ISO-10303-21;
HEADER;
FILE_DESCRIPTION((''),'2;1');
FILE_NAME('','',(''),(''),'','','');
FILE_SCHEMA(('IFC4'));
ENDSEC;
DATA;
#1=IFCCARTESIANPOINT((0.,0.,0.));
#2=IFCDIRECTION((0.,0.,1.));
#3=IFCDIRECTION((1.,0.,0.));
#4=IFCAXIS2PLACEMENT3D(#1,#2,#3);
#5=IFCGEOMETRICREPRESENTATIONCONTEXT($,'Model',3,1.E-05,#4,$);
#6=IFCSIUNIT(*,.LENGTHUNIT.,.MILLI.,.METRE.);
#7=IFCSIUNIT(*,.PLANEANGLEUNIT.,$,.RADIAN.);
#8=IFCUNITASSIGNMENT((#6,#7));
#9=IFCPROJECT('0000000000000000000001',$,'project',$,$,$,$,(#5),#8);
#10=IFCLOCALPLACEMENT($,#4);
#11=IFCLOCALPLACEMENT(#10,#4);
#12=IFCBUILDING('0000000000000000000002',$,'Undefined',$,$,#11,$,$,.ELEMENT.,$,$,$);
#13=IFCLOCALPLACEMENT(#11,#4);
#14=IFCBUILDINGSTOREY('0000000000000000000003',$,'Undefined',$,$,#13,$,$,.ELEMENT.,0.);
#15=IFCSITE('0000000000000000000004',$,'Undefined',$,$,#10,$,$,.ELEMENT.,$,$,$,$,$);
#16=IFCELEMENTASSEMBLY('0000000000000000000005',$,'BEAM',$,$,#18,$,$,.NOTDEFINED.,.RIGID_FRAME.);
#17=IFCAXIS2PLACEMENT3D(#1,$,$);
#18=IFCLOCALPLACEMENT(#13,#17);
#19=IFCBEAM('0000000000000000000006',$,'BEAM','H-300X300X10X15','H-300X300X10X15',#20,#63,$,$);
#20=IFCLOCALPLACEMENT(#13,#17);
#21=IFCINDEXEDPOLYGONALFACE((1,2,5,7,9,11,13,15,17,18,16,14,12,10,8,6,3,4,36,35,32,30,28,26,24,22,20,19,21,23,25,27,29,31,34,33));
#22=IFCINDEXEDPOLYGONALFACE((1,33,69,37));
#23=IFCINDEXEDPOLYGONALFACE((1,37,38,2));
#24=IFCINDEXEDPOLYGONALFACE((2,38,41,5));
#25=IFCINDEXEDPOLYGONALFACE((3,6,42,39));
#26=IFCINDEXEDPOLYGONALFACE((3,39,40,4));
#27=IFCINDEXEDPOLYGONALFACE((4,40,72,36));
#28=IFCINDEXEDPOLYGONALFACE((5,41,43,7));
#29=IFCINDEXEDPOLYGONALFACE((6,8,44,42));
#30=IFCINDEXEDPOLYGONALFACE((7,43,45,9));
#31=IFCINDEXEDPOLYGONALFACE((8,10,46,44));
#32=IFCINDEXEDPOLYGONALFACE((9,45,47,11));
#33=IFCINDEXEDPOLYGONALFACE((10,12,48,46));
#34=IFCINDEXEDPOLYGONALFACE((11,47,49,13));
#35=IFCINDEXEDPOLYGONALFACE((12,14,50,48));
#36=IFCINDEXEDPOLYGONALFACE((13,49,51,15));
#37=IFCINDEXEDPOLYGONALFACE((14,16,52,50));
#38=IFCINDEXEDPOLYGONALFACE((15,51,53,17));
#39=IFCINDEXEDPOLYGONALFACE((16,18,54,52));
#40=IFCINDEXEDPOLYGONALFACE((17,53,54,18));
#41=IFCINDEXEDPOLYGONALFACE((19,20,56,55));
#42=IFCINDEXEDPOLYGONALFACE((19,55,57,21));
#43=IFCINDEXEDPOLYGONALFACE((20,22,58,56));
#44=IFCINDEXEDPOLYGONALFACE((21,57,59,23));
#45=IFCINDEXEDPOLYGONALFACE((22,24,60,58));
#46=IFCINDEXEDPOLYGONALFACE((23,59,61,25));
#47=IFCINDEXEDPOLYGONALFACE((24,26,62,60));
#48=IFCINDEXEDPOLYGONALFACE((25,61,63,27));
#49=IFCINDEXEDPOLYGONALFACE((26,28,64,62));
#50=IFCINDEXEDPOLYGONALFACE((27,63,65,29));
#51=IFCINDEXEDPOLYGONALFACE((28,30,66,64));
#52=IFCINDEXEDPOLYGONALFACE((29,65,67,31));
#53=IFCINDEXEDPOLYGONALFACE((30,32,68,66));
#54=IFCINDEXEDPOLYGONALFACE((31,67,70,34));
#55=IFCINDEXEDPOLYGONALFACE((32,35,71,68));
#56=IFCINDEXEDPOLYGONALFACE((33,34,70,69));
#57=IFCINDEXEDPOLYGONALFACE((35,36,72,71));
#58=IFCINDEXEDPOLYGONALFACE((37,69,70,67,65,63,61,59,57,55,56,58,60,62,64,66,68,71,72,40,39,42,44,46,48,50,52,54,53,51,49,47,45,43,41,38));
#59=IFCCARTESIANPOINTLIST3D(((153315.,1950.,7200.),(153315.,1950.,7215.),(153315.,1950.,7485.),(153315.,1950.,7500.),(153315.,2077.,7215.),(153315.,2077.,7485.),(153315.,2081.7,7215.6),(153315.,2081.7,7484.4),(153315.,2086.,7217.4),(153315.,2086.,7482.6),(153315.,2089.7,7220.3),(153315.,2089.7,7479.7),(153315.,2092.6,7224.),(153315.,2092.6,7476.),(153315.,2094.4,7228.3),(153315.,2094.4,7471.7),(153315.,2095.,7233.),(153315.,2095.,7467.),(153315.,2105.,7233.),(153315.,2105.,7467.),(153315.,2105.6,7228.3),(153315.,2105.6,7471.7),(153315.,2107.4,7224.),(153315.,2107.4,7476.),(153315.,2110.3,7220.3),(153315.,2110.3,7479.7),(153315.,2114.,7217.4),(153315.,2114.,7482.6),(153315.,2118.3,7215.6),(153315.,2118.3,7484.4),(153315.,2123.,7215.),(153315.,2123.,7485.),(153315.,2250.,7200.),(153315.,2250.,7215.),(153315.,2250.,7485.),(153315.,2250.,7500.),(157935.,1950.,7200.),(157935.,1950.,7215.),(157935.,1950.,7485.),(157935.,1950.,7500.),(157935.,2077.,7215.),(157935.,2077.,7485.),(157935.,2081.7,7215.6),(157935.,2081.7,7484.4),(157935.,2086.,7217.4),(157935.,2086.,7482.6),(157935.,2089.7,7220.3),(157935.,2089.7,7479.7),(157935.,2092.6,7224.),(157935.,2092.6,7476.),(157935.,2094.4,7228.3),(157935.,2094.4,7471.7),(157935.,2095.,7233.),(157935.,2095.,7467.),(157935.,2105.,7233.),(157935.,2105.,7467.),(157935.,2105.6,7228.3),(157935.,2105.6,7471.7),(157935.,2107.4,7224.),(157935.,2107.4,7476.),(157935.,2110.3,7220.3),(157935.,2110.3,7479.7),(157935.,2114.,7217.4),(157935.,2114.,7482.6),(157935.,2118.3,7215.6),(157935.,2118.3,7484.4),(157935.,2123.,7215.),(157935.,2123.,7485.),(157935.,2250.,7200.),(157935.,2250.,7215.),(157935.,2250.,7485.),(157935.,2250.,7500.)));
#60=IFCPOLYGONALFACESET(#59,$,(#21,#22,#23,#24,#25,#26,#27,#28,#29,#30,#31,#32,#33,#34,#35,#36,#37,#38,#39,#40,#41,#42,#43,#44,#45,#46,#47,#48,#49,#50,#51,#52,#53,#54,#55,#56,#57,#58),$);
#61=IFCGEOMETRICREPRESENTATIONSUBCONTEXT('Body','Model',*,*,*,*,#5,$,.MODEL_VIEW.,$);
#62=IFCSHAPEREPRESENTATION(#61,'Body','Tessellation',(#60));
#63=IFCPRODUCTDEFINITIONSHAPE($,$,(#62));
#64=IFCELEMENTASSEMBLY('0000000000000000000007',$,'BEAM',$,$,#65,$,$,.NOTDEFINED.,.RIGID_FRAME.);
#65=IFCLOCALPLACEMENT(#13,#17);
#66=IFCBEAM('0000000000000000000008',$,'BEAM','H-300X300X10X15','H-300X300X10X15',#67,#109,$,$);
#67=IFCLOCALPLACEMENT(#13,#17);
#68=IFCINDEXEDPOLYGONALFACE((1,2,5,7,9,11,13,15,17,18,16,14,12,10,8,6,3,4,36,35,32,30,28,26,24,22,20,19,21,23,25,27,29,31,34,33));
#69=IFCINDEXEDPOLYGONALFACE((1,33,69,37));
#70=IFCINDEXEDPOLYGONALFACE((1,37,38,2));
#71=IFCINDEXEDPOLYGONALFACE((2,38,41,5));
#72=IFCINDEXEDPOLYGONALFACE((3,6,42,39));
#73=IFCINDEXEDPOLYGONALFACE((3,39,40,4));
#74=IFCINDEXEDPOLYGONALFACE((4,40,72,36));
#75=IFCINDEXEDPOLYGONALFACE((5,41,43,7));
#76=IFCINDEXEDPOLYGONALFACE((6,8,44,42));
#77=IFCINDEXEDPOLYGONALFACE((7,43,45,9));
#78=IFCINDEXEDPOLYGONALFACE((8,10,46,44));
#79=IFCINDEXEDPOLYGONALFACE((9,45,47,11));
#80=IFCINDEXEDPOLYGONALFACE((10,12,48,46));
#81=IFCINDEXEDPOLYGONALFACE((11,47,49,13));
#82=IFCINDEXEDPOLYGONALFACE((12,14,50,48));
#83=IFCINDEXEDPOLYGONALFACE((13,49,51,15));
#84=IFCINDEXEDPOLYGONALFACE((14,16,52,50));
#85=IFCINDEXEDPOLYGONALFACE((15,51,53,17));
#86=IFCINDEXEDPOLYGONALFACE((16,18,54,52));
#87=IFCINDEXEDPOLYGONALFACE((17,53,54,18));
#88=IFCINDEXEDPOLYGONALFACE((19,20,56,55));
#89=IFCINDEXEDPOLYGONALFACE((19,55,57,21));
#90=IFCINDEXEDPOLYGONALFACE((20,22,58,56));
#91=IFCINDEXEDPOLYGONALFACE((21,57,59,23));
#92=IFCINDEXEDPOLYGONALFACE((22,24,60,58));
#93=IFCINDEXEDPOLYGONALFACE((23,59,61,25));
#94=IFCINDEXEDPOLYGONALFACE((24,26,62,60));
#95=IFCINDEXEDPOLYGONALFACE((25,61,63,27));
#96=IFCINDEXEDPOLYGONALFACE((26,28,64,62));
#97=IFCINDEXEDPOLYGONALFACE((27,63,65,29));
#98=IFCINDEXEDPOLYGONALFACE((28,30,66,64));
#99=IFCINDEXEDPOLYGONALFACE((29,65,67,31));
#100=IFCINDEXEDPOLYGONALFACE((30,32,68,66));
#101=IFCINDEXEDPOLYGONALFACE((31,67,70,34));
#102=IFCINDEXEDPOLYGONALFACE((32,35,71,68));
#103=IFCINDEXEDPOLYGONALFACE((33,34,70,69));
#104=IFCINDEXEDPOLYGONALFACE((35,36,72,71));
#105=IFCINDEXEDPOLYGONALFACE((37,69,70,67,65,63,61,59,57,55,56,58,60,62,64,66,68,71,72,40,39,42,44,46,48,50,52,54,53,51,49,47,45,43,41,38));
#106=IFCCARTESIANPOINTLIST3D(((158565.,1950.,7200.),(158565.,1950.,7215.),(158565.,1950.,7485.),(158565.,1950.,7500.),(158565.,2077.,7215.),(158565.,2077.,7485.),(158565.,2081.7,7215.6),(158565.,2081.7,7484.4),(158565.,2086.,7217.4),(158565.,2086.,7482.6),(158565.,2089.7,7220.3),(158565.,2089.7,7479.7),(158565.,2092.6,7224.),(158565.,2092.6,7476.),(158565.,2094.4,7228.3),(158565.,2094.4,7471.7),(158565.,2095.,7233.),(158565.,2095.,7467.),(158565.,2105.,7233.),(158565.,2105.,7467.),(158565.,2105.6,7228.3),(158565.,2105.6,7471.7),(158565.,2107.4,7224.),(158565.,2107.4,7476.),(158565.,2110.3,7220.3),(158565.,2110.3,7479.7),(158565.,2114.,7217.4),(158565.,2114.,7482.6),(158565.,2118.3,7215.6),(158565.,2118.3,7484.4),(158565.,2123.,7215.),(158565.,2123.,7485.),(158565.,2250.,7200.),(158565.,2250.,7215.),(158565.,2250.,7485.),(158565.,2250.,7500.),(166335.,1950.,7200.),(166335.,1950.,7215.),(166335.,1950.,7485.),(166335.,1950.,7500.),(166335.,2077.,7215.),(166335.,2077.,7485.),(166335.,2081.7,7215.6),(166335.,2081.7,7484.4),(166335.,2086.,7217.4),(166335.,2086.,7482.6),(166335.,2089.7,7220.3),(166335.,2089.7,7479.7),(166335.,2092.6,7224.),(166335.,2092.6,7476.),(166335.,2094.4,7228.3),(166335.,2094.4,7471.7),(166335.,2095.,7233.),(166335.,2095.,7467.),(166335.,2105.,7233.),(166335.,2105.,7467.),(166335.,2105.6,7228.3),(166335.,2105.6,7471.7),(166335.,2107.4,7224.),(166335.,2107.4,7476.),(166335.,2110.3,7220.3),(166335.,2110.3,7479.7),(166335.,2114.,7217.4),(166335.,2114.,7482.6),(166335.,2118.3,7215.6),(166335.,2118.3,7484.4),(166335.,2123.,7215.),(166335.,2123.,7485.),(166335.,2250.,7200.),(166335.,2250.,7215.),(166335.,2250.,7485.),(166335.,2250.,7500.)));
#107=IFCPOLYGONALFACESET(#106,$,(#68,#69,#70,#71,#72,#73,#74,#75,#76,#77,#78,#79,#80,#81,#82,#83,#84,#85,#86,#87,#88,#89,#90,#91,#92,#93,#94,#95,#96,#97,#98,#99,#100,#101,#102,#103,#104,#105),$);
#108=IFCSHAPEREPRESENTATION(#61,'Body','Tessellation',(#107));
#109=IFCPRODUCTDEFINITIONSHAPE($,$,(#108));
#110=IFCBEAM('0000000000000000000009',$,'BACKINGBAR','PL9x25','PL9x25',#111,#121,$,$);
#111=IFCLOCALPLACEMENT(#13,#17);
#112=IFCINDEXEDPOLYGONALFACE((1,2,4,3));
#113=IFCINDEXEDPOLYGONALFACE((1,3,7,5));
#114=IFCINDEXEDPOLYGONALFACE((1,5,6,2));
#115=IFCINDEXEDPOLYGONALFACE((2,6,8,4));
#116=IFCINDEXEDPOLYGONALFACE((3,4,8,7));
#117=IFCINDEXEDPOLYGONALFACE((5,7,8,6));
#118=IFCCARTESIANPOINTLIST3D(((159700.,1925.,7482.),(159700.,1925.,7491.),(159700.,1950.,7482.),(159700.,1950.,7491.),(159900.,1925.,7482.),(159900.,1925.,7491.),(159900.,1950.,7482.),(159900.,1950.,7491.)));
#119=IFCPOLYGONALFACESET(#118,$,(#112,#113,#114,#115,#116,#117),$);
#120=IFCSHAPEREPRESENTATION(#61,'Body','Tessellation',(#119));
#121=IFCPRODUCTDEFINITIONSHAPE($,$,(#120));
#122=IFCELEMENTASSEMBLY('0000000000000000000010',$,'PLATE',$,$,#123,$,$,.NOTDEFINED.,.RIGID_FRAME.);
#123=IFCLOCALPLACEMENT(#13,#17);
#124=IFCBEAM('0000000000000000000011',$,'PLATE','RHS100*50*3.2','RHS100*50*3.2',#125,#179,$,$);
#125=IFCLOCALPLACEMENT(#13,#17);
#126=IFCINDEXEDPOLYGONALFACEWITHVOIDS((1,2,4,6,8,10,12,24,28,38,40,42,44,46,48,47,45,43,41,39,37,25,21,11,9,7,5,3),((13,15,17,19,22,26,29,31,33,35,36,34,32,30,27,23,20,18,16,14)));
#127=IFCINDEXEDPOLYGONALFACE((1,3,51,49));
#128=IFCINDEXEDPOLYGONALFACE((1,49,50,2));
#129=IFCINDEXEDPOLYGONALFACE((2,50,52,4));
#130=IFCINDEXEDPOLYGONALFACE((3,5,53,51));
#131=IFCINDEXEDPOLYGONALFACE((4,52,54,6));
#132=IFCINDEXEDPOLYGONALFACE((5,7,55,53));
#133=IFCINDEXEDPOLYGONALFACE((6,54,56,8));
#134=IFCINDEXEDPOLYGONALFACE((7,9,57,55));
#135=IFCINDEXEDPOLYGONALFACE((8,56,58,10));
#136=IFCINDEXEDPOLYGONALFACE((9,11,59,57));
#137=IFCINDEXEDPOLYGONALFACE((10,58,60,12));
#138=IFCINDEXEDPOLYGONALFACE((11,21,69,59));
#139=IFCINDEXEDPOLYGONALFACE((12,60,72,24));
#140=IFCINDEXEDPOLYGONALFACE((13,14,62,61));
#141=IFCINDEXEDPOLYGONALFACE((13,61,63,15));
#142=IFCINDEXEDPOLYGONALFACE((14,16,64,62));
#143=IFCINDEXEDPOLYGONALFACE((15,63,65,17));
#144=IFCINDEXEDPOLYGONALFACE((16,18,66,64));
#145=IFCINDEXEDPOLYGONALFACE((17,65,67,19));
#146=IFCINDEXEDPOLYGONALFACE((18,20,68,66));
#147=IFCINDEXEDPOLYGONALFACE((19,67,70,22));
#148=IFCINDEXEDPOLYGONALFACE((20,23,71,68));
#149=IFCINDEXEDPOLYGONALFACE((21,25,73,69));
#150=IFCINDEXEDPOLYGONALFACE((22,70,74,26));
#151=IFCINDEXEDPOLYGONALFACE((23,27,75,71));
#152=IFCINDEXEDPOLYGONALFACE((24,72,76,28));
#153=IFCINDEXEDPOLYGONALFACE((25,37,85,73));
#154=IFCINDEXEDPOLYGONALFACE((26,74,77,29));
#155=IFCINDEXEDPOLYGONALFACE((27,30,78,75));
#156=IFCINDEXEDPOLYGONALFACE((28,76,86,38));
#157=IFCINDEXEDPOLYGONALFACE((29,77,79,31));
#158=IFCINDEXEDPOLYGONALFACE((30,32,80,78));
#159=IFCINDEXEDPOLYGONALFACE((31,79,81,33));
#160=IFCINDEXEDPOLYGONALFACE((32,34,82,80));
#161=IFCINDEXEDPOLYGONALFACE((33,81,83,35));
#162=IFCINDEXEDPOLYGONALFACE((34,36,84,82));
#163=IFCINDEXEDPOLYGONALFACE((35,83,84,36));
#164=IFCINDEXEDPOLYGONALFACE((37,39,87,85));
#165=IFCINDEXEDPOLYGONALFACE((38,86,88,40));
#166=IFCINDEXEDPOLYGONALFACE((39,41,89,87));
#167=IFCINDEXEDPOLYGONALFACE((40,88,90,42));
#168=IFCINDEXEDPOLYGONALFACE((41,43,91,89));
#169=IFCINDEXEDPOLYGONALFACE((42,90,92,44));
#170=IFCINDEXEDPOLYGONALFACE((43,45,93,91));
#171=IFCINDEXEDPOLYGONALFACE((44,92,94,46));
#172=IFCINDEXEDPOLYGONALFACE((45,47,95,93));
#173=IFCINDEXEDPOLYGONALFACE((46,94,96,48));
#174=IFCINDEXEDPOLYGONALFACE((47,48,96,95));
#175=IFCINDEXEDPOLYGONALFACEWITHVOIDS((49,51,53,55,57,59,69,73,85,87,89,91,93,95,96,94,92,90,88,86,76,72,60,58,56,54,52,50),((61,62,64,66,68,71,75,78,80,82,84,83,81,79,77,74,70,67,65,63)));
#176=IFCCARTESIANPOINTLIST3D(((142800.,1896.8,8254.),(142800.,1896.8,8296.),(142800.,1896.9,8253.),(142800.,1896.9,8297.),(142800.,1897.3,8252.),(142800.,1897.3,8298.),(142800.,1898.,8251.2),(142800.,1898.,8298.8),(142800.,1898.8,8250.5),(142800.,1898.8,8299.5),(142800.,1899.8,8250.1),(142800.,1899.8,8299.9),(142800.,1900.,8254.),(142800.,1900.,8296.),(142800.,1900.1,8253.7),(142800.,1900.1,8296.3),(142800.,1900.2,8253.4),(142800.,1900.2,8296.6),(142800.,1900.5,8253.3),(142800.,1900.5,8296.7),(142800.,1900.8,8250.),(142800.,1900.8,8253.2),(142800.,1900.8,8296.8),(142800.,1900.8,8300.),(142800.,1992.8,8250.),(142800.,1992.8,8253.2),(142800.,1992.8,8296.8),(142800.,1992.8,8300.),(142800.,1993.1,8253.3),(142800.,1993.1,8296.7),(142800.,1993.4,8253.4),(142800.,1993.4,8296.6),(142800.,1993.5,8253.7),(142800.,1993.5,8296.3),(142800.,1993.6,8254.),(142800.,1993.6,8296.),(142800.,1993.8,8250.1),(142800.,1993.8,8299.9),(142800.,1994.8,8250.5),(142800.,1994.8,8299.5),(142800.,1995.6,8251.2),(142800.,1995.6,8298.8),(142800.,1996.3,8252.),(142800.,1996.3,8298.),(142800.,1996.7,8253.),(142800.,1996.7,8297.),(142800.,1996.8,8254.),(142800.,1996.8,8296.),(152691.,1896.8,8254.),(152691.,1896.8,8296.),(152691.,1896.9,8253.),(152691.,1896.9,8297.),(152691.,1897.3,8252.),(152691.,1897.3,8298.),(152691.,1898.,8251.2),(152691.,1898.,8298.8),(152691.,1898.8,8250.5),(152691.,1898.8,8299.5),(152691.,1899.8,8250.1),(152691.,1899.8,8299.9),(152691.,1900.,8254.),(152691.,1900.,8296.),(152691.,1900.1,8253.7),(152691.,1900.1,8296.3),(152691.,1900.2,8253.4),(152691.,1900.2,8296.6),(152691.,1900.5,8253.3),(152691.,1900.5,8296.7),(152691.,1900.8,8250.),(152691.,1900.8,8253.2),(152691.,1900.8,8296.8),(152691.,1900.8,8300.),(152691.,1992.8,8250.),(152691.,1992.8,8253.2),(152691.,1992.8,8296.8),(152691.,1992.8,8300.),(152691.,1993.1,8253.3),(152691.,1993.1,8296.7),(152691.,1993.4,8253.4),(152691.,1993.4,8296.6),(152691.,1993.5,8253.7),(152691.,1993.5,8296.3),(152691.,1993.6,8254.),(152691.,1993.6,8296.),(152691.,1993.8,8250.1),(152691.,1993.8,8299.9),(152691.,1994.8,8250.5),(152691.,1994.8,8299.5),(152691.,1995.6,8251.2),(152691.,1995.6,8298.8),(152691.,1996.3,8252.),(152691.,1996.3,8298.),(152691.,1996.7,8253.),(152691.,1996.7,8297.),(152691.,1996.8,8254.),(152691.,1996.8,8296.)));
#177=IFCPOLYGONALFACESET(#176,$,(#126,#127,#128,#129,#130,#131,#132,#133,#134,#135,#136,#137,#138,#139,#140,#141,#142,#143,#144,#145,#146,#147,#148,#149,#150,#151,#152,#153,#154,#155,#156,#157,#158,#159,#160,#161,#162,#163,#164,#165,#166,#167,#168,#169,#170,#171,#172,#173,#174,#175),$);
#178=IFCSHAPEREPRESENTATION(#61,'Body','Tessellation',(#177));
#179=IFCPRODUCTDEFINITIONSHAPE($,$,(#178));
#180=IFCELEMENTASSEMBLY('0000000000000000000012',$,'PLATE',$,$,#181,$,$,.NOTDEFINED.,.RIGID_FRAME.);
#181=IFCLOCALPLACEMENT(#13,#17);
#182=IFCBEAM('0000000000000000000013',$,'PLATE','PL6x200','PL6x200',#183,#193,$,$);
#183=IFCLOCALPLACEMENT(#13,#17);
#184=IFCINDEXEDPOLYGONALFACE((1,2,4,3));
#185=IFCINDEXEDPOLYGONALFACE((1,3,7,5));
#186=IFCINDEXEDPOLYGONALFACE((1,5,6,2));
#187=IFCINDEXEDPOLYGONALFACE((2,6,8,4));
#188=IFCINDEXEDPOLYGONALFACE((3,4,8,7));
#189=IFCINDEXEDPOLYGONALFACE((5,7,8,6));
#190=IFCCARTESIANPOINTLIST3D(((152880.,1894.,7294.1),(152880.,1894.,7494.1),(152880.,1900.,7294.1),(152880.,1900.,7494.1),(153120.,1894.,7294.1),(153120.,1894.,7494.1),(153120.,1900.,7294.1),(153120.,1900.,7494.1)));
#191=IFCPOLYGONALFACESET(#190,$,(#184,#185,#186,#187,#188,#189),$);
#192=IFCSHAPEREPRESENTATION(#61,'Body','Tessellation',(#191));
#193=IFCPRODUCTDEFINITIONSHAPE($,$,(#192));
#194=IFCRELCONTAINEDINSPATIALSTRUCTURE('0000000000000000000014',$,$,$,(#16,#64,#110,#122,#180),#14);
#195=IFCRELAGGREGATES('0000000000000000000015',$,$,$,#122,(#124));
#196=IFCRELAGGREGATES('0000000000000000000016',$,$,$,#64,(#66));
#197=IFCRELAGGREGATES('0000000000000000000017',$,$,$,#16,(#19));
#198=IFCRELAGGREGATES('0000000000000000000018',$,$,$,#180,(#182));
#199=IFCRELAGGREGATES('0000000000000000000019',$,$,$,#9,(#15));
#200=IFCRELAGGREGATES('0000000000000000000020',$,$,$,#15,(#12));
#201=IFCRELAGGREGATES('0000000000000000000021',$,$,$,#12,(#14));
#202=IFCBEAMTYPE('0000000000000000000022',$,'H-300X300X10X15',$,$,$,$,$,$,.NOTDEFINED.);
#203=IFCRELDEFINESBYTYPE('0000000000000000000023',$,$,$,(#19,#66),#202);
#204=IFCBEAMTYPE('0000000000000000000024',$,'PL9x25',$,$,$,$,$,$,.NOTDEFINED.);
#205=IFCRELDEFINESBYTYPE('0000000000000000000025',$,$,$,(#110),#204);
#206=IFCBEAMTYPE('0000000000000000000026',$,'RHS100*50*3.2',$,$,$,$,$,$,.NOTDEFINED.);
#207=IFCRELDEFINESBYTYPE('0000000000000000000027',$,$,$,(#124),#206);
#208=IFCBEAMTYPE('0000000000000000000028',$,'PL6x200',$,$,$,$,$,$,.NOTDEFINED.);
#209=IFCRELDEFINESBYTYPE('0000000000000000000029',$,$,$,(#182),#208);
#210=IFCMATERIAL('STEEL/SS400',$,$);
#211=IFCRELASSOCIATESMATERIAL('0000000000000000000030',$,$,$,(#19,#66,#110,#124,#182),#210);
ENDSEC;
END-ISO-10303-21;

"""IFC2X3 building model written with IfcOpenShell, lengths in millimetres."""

from ifc_helpers import new_model, si_unit, frame, origin_with_axes, origin_2d_with_axis, place, context, subcontext, project, spatial, rectangle, hollow_rectangle, i_section, extrude, clip, halfspace, material, type_object, element, aggregate, save


model = new_model("IFC2X3")

# Units and contexts
model_context = context("Model", 3, precision=1e-05, world=origin_with_axes())
body_context = subcontext(model_context, "Body", "Model", "MODEL_VIEW")
ifc_project = project(units=[si_unit("LENGTHUNIT", "METRE", prefix="MILLI"), si_unit("PLANEANGLEUNIT", "RADIAN")], contexts=[model_context])

# Site, building, storey
site_placement = place(None, origin_with_axes())
site = spatial("IfcSite", under=ifc_project, at=site_placement, Name="Undefined", CompositionType="ELEMENT")
building_placement = place(site_placement, origin_with_axes())
building = spatial("IfcBuilding", under=site, at=building_placement, Name="Undefined", CompositionType="ELEMENT")
storey_placement = place(building_placement, origin_with_axes())
storey = spatial("IfcBuildingStorey", under=building, at=storey_placement, Name="Undefined", CompositionType="ELEMENT", Elevation=0.0)

# Shared definitions
ifc_material_1 = material(Name="STEEL/SS400")

# Element assemblies, beams
beam_type_1 = type_object("IfcBeamType", Name="H-300X300X10X15", PredefinedType="NOTDEFINED")
assembly_1_placement = place(storey_placement, origin_with_axes())
assembly_1 = element("IfcElementAssembly", 1, at=assembly_1_placement, inside=storey, Name="BEAM", AssemblyPlace="NOTDEFINED", PredefinedType="RIGID_FRAME")
beam_1_placement = place(assembly_1_placement, frame((153300.0, 2100.0, 7350.0), z_axis=(0.0, 0.0, 1.0), x_axis=(1.0, 0.0, 0.0)))
beam_1 = element("IfcBeam", 2, at=beam_1_placement, type_object=beam_type_1, material=ifc_material_1, Name="BEAM", Description="H-300X300X10X15", ObjectType="H-300X300X10X15", context=body_context, shape_type="Clipping", body=[
    clip(clip(extrude(i_section(OverallWidth=300.0, OverallDepth=300.0, WebThickness=10.0, FlangeThickness=15.0, FilletRadius=18.0, at=origin_2d_with_axis()), frame((4635.0, 0.0, 0.0), z_axis=(-1.0, 0.0, 0.0), x_axis=(0.0, -1.0, 0.0)), (0.0, 0.0, 1.0), 4620.0), halfspace(frame((4635.0, 0.0, -150.0), z_axis=(-1.0, 0.0, 0.0), x_axis=(0.0, 1.0, 0.0)), True)), halfspace(frame((15.0, 0.0, -150.0), z_axis=(1.0, 0.0, 0.0), x_axis=(0.0, -1.0, 0.0)), True)),
])
assembly_2_placement = place(storey_placement, origin_with_axes())
assembly_2 = element("IfcElementAssembly", 3, at=assembly_2_placement, inside=storey, Name="BEAM", AssemblyPlace="NOTDEFINED", PredefinedType="RIGID_FRAME")
beam_2_placement = place(assembly_2_placement, frame((158550.0, 2100.0, 7350.0), z_axis=(0.0, 0.0, 1.0), x_axis=(1.0, 0.0, 0.0)))
beam_2 = element("IfcBeam", 4, at=beam_2_placement, type_object=beam_type_1, material=ifc_material_1, Name="BEAM", Description="H-300X300X10X15", ObjectType="H-300X300X10X15", context=body_context, shape_type="Clipping", body=[
    clip(clip(extrude(i_section(OverallWidth=300.0, OverallDepth=300.0, WebThickness=10.0, FlangeThickness=15.0, FilletRadius=18.0, at=origin_2d_with_axis()), frame((7785.0, 0.0, 0.0), z_axis=(-1.0, 0.0, 0.0), x_axis=(0.0, -1.0, 0.0)), (0.0, 0.0, 1.0), 7770.0), halfspace(frame((7785.0, 0.0, -150.0), z_axis=(-1.0, 0.0, 0.0), x_axis=(0.0, 1.0, 0.0)), True)), halfspace(frame((15.0, 0.0, -150.0), z_axis=(1.0, 0.0, 0.0), x_axis=(0.0, -1.0, 0.0)), True)),
])

# Beam
beam_type_2 = type_object("IfcBeamType", Name="PL9x25", PredefinedType="NOTDEFINED")
beam_3_placement = place(storey_placement, frame((159900.0, 1937.5, 7486.5), z_axis=(0.0, -1.0, 0.0), x_axis=(-1.0, 0.0, 0.0)))
element("IfcBeam", 5, at=beam_3_placement, inside=storey, type_object=beam_type_2, material=ifc_material_1, Name="BACKINGBAR", Description="PL9x25", ObjectType="PL9x25", context=body_context, shape_type="SweptSolid", body=[
    extrude(rectangle(XDim=9.0, YDim=25.0, at=origin_2d_with_axis()), frame((200.0, 0.0, 0.0), z_axis=(-1.0, 0.0, 0.0), x_axis=(0.0, -1.0, 0.0)), (0.0, 0.0, 1.0), 200.0),
])

# Element assemblies, beams
assembly_3_placement = place(storey_placement, origin_with_axes())
assembly_3 = element("IfcElementAssembly", 6, at=assembly_3_placement, inside=storey, Name="PLATE", AssemblyPlace="NOTDEFINED", PredefinedType="RIGID_FRAME")
beam_type_3 = type_object("IfcBeamType", Name="RHS100*50*3.2", PredefinedType="NOTDEFINED")
beam_4_placement = place(assembly_3_placement, frame((152700.0, 1946.8, 8275.0), z_axis=(0.0, -1.0, 0.0), x_axis=(-1.0, 0.0, 0.0)))
beam_4 = element("IfcBeam", 7, at=beam_4_placement, type_object=beam_type_3, material=ifc_material_1, Name="PLATE", Description="RHS100*50*3.2", ObjectType="RHS100*50*3.2", context=body_context, shape_type="Clipping", body=[
    clip(extrude(hollow_rectangle(XDim=50.0, YDim=100.0, WallThickness=3.2, InnerFilletRadius=0.8, OuterFilletRadius=4.0, at=origin_2d_with_axis()), frame((9900.0, 0.0, 0.0), z_axis=(-1.0, 0.0, 0.0), x_axis=(0.0, -1.0, 0.0)), (0.0, 0.0, 1.0), 9891.0), halfspace(frame((9.0, 0.0, -50.0), z_axis=(1.0, 0.0, 0.0), x_axis=(0.0, -1.0, 0.0)), True)),
])
aggregate(assembly_3, [beam_4])
assembly_4_placement = place(storey_placement, origin_with_axes())
assembly_4 = element("IfcElementAssembly", 8, at=assembly_4_placement, inside=storey, Name="PLATE", AssemblyPlace="NOTDEFINED", PredefinedType="RIGID_FRAME")
beam_type_4 = type_object("IfcBeamType", Name="PL6x200", PredefinedType="NOTDEFINED")
beam_5_placement = place(assembly_4_placement, frame((153120.0, 1897.0, 7394.1), z_axis=(0.0, 0.0, 1.0), x_axis=(-1.0, 0.0, 0.0)))
beam_5 = element("IfcBeam", 9, at=beam_5_placement, type_object=beam_type_4, material=ifc_material_1, Name="PLATE", Description="PL6x200", ObjectType="PL6x200", context=body_context, shape_type="SweptSolid", body=[
    extrude(rectangle(XDim=6.0, YDim=200.0, at=origin_2d_with_axis()), frame((240.0, 0.0, 0.0), z_axis=(-1.0, 0.0, 0.0), x_axis=(0.0, -1.0, 0.0)), (0.0, 0.0, 1.0), 240.0),
])

aggregate(assembly_2, [beam_2])
aggregate(assembly_1, [beam_1])

aggregate(assembly_4, [beam_5])

save(model, "model.ifc")
